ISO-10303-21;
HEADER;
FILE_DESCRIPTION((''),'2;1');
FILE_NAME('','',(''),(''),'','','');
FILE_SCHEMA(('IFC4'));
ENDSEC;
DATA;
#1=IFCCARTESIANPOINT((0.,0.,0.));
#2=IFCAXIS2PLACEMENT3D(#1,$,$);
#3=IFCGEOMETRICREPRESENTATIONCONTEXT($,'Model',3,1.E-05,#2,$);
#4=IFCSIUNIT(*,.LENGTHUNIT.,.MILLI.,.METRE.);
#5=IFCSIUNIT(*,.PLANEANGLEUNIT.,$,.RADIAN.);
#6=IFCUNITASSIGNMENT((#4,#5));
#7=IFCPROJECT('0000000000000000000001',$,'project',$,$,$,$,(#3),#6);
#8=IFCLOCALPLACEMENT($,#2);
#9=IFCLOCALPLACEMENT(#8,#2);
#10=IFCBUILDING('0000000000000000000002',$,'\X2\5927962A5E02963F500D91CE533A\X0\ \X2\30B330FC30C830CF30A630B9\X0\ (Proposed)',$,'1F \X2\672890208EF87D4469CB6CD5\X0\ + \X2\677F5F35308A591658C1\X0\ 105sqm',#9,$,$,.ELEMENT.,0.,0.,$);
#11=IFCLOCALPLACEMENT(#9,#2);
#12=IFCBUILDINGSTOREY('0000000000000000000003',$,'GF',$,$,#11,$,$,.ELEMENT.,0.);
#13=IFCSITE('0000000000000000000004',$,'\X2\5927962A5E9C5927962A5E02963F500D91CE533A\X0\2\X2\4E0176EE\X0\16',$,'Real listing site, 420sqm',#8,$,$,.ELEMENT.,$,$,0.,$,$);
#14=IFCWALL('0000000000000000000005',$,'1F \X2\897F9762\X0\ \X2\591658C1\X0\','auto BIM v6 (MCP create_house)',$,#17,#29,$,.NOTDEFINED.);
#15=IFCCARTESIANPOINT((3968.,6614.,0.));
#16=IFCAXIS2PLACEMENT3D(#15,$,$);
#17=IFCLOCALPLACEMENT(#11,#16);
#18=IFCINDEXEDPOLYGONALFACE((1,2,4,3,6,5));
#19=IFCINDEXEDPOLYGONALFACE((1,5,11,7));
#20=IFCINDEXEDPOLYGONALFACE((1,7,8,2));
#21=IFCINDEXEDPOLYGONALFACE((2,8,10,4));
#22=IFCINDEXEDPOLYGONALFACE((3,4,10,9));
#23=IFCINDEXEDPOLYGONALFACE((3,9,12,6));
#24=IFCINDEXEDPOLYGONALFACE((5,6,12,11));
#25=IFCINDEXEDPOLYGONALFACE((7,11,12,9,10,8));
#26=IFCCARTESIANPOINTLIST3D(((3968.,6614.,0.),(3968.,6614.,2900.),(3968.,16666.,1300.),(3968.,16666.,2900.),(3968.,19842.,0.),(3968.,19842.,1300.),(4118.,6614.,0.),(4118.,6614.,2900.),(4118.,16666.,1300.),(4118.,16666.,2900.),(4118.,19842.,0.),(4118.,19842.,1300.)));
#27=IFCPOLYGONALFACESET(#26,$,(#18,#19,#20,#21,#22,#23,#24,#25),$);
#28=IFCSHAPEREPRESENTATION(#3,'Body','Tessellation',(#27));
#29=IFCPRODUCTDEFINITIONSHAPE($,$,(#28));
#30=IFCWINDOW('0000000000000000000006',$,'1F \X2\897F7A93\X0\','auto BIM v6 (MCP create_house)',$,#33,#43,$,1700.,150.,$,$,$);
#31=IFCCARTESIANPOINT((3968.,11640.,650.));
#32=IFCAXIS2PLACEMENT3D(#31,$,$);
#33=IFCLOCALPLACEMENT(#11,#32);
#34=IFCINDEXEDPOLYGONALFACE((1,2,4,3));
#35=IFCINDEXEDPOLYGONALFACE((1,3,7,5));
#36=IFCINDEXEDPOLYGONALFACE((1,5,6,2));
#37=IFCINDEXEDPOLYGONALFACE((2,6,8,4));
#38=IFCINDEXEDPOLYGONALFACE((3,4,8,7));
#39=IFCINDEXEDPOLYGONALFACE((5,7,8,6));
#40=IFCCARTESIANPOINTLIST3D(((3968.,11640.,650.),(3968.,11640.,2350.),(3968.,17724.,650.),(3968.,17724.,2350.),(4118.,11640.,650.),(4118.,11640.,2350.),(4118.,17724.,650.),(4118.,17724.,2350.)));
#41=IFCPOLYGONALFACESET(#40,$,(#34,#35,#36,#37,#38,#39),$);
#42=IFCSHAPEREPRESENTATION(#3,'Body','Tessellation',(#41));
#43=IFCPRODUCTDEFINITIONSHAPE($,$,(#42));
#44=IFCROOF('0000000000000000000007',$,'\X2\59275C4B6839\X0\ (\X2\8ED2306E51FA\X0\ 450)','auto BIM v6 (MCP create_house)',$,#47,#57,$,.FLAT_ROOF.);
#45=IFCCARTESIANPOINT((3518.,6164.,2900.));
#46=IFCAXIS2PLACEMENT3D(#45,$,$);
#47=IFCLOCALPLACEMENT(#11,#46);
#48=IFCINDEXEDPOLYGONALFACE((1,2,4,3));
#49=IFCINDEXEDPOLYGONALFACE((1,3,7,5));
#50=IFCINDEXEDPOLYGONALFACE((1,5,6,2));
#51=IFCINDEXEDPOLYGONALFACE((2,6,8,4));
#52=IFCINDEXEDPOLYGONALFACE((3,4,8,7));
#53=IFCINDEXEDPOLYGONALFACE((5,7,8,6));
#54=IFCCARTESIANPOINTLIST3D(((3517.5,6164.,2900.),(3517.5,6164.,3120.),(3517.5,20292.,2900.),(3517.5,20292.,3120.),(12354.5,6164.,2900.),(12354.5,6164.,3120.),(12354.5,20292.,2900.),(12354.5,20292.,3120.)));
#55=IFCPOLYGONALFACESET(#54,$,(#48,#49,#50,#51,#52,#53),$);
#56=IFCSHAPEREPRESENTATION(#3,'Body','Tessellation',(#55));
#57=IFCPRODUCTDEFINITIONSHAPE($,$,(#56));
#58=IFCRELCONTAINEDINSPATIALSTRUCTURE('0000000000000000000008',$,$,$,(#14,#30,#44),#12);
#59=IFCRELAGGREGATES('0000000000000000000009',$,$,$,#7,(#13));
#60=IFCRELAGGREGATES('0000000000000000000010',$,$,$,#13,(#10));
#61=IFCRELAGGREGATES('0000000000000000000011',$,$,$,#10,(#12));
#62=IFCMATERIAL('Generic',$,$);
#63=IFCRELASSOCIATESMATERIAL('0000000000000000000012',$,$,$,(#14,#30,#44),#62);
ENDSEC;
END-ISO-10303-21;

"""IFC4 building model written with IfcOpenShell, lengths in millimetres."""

from ifc_helpers import new_model, si_unit, frame, frame_2d, origin, place, context, project, spatial, rectangle, extrude, material, element, fill, save


model = new_model("IFC4")

# Units and contexts
model_context = context("Model", 3, precision=1e-05, world=origin())
ifc_project = project(units=[si_unit("LENGTHUNIT", "METRE", prefix="MILLI"), si_unit("PLANEANGLEUNIT", "RADIAN")], contexts=[model_context])

# Site, building, storey
site_placement = place(None, origin())
site = spatial("IfcSite", under=ifc_project, at=site_placement, Name="大阪府大阪市阿倍野区2丁目16", ObjectType="Real listing site, 420sqm", CompositionType="ELEMENT", RefElevation=0.0)
building_placement = place(site_placement, origin())
building = spatial("IfcBuilding", under=site, at=building_placement, Name="大阪市阿倍野区 コートハウス (Proposed)", ObjectType="1F 木造軸組構法 + 板張り外壁 105sqm", CompositionType="ELEMENT", ElevationOfRefHeight=0.0, ElevationOfTerrain=0.0)
storey_placement = place(building_placement, origin())
storey = spatial("IfcBuildingStorey", under=building, at=storey_placement, Name="GF", CompositionType="ELEMENT", Elevation=0.0)

# Shared definitions
ifc_material = material(Name="Generic")

# Wall, opening, window
wall_1_placement = place(storey_placement, frame((3968.0, 6614.0, 0.0)))
wall_1 = element("IfcWall", 1, at=wall_1_placement, inside=storey, material=ifc_material, Name="1F 西面 外壁", Description="auto BIM v6 (MCP create_house)", PredefinedType="NOTDEFINED", context=model_context, shape_type="SweptSolid", body=[
    extrude(rectangle(XDim=150.0, YDim=13228.0, at=frame_2d((75.0, 6614.0))), frame((3968.0, 6614.0, 0.0)), (0.0, 0.0, 1.0), 2900.0),
])
opening_1_placement = place(storey_placement, frame((3968.0, 11640.0, 650.0)))
opening_1 = element("IfcOpeningElement", 2, at=opening_1_placement, cuts=wall_1, PredefinedType="NOTDEFINED", context=model_context, shape_type="SweptSolid", body=[
    extrude(rectangle(XDim=150.0, YDim=6084.0, at=frame_2d((75.0, 3042.0))), frame((3968.0, 11640.0, 650.0)), (0.0, 0.0, 1.0), 1700.0),
])
window_1_placement = place(storey_placement, frame((3968.0, 11640.0, 650.0)))
window_1 = element("IfcWindow", 3, at=window_1_placement, inside=storey, material=ifc_material, Name="1F 西窓", Description="auto BIM v6 (MCP create_house)", OverallHeight=1700.0, OverallWidth=150.0, context=model_context, shape_type="SweptSolid", body=[
    extrude(rectangle(XDim=150.0, YDim=6084.0, at=frame_2d((75.0, 3042.0))), frame((3968.0, 11640.0, 650.0)), (0.0, 0.0, 1.0), 1700.0),
])
fill(opening_1, window_1)

# Roof
roof_placement = place(storey_placement, frame((3518.0, 6164.0, 2900.0)))
element("IfcRoof", 4, at=roof_placement, inside=storey, material=ifc_material, Name="大屋根 (軒の出 450)", Description="auto BIM v6 (MCP create_house)", PredefinedType="FLAT_ROOF", context=model_context, shape_type="SweptSolid", body=[
    extrude(rectangle(XDim=8837.0, YDim=14128.0, at=frame_2d((4418.0, 7064.0))), frame((3518.0, 6164.0, 2900.0)), (0.0, 0.0, 1.0), 220.0),
])

save(model, "model.ifc")
